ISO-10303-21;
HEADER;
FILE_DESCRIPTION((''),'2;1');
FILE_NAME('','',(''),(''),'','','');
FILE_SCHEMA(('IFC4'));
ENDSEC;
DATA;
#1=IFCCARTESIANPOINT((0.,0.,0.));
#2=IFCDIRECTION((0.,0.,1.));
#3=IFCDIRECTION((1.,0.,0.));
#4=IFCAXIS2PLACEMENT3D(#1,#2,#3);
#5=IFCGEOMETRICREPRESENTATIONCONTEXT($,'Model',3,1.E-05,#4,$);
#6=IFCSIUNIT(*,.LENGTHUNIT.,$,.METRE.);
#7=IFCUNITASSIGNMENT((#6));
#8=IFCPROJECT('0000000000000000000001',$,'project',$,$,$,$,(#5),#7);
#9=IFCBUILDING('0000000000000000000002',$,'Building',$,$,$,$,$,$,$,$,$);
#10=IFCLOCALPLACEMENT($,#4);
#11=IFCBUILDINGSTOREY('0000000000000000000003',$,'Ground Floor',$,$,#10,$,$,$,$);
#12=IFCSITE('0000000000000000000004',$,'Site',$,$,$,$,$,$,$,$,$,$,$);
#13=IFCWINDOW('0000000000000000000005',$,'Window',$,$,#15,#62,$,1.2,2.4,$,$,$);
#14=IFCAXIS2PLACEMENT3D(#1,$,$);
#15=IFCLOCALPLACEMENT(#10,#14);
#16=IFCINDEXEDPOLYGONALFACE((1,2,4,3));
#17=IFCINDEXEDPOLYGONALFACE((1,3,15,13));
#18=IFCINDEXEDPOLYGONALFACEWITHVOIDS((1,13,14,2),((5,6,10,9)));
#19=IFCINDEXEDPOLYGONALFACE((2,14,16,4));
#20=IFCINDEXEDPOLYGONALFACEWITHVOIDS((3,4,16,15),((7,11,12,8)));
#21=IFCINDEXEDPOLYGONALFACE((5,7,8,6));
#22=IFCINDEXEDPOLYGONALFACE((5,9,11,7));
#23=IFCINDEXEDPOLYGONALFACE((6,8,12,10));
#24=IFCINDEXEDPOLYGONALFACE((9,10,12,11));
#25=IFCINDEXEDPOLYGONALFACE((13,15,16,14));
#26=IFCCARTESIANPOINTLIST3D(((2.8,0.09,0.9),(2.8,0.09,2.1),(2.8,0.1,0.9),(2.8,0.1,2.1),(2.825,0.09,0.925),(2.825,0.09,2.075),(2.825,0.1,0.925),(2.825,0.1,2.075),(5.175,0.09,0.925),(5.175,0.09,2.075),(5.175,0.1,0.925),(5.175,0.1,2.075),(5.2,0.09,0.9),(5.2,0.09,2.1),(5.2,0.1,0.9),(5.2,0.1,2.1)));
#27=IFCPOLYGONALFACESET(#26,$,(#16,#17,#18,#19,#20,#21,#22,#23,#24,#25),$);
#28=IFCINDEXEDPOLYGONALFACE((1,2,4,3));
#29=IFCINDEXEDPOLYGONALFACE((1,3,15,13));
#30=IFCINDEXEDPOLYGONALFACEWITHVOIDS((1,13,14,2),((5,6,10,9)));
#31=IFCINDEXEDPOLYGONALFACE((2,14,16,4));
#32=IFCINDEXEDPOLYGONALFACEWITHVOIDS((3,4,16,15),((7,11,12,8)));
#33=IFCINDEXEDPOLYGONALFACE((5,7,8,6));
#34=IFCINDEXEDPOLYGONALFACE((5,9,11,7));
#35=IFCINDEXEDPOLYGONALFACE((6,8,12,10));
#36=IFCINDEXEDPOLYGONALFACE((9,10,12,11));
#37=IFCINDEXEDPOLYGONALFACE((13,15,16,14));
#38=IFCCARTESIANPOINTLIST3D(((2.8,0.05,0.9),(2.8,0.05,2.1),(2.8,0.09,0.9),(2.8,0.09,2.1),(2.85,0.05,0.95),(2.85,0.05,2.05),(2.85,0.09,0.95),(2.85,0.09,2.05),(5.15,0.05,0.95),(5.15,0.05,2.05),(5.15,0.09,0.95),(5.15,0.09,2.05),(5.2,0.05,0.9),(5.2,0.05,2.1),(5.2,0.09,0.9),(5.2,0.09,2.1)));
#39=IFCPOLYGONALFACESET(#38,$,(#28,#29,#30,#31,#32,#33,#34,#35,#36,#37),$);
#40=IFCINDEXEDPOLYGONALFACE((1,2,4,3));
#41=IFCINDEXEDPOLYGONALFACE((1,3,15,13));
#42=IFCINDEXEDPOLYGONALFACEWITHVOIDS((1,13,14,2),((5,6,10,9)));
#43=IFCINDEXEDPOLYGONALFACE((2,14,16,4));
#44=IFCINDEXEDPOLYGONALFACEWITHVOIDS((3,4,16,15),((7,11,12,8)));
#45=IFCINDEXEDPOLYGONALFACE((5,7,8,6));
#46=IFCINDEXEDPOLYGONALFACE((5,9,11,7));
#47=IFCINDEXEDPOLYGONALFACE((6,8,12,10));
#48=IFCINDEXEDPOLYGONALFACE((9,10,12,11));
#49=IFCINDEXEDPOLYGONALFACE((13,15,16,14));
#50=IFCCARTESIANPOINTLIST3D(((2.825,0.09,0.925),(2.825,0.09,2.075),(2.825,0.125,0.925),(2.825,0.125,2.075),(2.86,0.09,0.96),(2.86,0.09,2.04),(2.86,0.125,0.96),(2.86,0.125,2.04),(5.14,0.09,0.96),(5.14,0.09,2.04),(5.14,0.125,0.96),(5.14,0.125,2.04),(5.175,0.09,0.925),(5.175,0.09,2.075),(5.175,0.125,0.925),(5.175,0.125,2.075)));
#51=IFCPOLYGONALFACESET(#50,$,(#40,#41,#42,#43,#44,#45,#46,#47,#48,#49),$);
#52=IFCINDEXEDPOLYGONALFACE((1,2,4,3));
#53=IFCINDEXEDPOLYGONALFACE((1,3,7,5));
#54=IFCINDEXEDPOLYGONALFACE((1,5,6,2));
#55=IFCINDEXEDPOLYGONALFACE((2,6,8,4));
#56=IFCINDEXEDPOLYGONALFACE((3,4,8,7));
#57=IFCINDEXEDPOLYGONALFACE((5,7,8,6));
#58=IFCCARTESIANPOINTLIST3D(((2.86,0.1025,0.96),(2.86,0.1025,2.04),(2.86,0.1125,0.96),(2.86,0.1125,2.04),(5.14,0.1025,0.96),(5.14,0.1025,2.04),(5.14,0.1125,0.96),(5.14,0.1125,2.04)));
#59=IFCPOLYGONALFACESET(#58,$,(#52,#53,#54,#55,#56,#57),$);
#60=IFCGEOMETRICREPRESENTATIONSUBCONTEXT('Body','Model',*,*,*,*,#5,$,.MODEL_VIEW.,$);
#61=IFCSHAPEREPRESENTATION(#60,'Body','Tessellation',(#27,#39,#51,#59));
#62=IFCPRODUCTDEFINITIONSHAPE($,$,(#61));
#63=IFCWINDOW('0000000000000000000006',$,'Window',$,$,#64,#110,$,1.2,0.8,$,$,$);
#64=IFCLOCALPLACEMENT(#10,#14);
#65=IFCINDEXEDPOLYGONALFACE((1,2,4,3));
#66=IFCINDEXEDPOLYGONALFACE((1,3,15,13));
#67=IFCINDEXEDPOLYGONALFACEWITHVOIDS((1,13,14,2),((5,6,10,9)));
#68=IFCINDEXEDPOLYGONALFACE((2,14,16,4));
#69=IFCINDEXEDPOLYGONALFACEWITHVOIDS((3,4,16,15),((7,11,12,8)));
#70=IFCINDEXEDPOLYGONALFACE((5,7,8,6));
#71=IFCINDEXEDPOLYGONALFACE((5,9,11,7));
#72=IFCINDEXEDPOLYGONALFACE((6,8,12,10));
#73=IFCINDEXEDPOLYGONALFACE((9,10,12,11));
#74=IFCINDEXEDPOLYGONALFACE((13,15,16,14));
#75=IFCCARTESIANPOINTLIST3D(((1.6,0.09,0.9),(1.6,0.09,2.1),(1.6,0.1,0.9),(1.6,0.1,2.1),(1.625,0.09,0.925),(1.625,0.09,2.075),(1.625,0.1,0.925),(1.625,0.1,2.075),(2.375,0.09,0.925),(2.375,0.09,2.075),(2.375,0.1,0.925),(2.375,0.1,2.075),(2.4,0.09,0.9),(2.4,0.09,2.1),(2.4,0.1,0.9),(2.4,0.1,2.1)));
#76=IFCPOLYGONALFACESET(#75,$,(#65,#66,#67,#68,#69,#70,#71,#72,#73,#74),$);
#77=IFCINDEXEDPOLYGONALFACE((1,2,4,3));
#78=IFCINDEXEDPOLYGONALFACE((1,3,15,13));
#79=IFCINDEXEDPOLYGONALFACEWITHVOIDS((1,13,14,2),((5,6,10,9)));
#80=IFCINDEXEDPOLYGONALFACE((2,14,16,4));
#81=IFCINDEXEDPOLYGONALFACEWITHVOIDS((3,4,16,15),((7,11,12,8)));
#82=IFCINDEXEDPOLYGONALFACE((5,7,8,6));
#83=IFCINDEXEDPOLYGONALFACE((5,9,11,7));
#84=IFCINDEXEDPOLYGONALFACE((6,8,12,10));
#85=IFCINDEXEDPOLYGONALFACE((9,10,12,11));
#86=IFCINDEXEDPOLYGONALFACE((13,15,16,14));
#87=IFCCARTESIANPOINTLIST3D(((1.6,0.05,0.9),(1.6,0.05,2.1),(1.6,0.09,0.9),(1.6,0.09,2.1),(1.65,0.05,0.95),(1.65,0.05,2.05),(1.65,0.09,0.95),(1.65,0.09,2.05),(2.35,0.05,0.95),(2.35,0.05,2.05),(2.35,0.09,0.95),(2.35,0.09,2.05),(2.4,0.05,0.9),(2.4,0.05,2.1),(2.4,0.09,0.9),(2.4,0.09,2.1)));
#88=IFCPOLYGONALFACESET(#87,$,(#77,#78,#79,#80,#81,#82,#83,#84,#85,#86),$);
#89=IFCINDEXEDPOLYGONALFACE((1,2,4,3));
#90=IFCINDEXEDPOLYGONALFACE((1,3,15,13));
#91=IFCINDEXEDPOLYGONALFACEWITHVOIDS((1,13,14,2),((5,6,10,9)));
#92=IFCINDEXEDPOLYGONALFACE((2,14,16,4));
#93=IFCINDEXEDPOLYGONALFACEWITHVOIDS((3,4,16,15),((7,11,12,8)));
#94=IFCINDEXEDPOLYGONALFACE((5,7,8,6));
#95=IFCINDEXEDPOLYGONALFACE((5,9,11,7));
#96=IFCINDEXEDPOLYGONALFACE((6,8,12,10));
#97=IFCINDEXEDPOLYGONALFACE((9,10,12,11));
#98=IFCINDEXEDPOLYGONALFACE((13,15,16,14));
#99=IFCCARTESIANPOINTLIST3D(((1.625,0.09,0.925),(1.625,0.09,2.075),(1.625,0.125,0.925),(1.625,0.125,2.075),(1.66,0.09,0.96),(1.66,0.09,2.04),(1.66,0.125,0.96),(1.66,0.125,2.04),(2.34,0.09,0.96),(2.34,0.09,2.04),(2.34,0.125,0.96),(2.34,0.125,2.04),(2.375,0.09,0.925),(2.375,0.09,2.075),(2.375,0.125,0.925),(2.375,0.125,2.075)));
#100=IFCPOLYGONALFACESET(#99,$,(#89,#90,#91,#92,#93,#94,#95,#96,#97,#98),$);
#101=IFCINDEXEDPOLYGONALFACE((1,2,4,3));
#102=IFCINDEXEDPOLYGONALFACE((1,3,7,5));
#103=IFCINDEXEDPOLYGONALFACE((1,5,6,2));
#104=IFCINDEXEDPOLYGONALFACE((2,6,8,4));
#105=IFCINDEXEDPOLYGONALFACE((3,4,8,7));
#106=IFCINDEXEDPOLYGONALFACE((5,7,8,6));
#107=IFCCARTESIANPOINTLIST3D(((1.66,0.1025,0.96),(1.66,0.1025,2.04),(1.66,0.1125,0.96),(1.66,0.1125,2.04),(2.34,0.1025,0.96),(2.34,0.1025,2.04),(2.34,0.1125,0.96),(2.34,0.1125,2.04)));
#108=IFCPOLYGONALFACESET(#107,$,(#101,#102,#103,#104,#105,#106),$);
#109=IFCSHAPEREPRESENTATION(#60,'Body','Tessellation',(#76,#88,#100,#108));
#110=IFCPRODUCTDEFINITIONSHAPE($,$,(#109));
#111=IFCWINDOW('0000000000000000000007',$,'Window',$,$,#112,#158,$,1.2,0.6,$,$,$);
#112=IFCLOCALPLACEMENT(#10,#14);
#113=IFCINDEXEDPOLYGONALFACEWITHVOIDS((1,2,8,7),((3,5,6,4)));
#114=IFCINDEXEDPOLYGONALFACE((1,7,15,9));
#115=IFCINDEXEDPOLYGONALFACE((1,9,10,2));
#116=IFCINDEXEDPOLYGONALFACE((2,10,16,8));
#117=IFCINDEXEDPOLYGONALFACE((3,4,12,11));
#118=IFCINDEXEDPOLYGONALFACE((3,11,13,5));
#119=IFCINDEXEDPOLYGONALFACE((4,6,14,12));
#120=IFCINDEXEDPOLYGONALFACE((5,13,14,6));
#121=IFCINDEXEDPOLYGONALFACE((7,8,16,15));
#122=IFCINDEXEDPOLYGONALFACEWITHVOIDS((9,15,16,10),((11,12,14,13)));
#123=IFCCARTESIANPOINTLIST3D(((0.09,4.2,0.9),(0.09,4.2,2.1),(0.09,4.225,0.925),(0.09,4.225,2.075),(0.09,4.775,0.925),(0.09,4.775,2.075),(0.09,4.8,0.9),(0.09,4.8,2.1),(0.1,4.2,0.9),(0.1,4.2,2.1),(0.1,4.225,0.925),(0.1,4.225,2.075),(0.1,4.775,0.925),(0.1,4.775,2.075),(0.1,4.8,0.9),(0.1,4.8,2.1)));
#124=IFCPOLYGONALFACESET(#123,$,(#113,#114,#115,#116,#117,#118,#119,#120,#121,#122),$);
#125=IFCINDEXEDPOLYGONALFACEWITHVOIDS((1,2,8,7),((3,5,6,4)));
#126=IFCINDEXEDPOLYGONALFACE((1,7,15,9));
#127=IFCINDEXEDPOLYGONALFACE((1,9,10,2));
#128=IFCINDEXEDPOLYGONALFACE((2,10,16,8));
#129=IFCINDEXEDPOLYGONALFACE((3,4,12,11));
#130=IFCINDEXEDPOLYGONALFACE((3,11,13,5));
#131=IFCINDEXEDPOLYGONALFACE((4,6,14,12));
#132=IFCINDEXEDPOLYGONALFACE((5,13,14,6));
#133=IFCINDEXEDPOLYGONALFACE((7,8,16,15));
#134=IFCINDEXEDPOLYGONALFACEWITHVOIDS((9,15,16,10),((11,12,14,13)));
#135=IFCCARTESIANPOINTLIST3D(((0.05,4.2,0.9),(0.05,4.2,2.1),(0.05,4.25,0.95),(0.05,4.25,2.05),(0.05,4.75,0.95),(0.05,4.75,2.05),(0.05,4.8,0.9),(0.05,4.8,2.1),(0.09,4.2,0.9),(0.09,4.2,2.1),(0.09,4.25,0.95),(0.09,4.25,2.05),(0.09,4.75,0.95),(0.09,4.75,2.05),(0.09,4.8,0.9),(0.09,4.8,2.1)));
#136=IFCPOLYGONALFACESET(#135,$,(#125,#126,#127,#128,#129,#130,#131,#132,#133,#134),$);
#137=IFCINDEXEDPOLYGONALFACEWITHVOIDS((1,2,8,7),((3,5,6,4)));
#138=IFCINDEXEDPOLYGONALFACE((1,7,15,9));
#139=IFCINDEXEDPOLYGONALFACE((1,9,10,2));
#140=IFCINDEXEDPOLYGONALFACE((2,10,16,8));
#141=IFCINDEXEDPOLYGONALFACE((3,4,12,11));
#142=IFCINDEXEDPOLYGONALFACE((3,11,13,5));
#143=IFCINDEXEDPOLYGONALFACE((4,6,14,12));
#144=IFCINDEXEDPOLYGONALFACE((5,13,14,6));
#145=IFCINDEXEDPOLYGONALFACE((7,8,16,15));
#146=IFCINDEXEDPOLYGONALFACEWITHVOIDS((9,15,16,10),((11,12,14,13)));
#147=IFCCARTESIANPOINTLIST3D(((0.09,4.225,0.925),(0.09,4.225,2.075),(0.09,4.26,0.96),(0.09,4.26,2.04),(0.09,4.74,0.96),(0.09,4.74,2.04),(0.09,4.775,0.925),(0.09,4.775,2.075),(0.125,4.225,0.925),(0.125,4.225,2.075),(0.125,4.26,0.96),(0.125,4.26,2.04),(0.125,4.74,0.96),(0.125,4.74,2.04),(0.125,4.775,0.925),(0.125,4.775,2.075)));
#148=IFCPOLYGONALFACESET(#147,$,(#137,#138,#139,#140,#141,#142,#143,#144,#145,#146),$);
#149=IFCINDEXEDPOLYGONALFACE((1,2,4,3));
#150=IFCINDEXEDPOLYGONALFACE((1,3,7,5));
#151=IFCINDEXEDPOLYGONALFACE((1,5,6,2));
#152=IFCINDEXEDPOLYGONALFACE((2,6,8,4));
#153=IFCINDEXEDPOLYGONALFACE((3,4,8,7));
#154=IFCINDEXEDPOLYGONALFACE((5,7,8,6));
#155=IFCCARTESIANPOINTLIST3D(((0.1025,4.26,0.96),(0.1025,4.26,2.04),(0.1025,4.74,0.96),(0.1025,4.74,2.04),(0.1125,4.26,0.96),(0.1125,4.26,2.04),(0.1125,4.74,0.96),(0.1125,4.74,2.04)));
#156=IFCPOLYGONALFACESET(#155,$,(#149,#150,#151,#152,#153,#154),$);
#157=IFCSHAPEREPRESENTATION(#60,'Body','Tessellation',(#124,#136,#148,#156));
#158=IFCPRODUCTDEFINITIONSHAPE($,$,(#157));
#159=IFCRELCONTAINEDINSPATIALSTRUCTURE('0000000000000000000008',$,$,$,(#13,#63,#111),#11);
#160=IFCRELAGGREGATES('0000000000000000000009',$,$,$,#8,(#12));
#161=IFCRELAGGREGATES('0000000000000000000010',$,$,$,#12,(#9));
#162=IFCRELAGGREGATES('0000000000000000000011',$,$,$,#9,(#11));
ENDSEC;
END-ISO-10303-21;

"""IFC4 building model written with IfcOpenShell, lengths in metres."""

from ifc_helpers import new_model, si_unit, frame, origin_with_axes, place, context, subcontext, project, spatial, line, indexed_curve, outline, extrude, element, save


model = new_model("IFC4")

# Units and contexts
model_context = context("Model", 3, precision=1e-05, world=origin_with_axes())
body_context = subcontext(model_context, "Body", "Model", "MODEL_VIEW")
ifc_project = project(units=[si_unit("LENGTHUNIT", "METRE")], contexts=[model_context])

# Site, building, storey
site = spatial("IfcSite", under=ifc_project, Name="Site")
building = spatial("IfcBuilding", under=site, Name="Building")
storey_placement = place(None, origin_with_axes())
storey = spatial("IfcBuildingStorey", under=building, at=storey_placement, Name="Ground Floor")

# Windows
window_1_placement = place(storey_placement, frame((2.8, 0.0, 0.9), z_axis=(0.0, 0.0, 1.0), x_axis=(1.0, 0.0, 0.0)))
element("IfcWindow", 1, at=window_1_placement, inside=storey, Name="Window", OverallHeight=1.2, OverallWidth=2.4, context=body_context, shape_type="SweptSolid", body=[
    extrude(outline(indexed_curve([(0.0, 0.0), (2.4, 0.0), (2.4, 1.2), (0.0, 1.2)], segments=[line(1, 2, 3, 4, 1)]), holes=[indexed_curve([(0.025, 0.025), (2.375, 0.025), (2.375, 1.175), (0.025, 1.175)], segments=[line(1, 2, 3, 4, 1)])]), frame((0.0, 0.09, 0.0), z_axis=(0.0, -1.0, 0.0), x_axis=(1.0, 0.0, 0.0)), (0.0, 0.0, -1.0), 0.01),
    extrude(outline(indexed_curve([(0.0, 0.0), (2.4, 0.0), (2.4, 1.2), (0.0, 1.2)], segments=[line(1, 2, 3, 4, 1)]), holes=[indexed_curve([(0.05, 0.05), (2.35, 0.05), (2.35, 1.15), (0.05, 1.15)], segments=[line(1, 2, 3, 4, 1)])]), frame((0.0, 0.05, 0.0), z_axis=(0.0, -1.0, 0.0), x_axis=(1.0, 0.0, 0.0)), (0.0, 0.0, -1.0), 0.04),
    extrude(outline(indexed_curve([(0.0, 0.0), (2.35, 0.0), (2.35, 1.15), (0.0, 1.15)], segments=[line(1, 2, 3, 4, 1)]), holes=[indexed_curve([(0.035, 0.035), (2.315, 0.035), (2.315, 1.115), (0.035, 1.115)], segments=[line(1, 2, 3, 4, 1)])]), frame((0.025, 0.09, 0.025), z_axis=(0.0, -1.0, 0.0), x_axis=(1.0, 0.0, 0.0)), (0.0, 0.0, -1.0), 0.035),
    extrude(outline(indexed_curve([(0.035, 0.035), (2.315, 0.035), (2.315, 1.115), (0.035, 1.115)], segments=[line(1, 2, 3, 4, 1)])), frame((0.025, 0.1025, 0.025), z_axis=(0.0, -1.0, 0.0), x_axis=(1.0, 0.0, 0.0)), (0.0, 0.0, -1.0), 0.01),
])
window_2_placement = place(storey_placement, frame((1.6, 0.0, 0.9), z_axis=(0.0, 0.0, 1.0), x_axis=(1.0, 0.0, 0.0)))
element("IfcWindow", 2, at=window_2_placement, inside=storey, Name="Window", OverallHeight=1.2, OverallWidth=0.8, context=body_context, shape_type="SweptSolid", body=[
    extrude(outline(indexed_curve([(0.0, 0.0), (0.8, 0.0), (0.8, 1.2), (0.0, 1.2)], segments=[line(1, 2, 3, 4, 1)]), holes=[indexed_curve([(0.025, 0.025), (0.775, 0.025), (0.775, 1.175), (0.025, 1.175)], segments=[line(1, 2, 3, 4, 1)])]), frame((0.0, 0.09, 0.0), z_axis=(0.0, -1.0, 0.0), x_axis=(1.0, 0.0, 0.0)), (0.0, 0.0, -1.0), 0.01),
    extrude(outline(indexed_curve([(0.0, 0.0), (0.8, 0.0), (0.8, 1.2), (0.0, 1.2)], segments=[line(1, 2, 3, 4, 1)]), holes=[indexed_curve([(0.05, 0.05), (0.75, 0.05), (0.75, 1.15), (0.05, 1.15)], segments=[line(1, 2, 3, 4, 1)])]), frame((0.0, 0.05, 0.0), z_axis=(0.0, -1.0, 0.0), x_axis=(1.0, 0.0, 0.0)), (0.0, 0.0, -1.0), 0.04),
    extrude(outline(indexed_curve([(0.0, 0.0), (0.75, 0.0), (0.75, 1.15), (0.0, 1.15)], segments=[line(1, 2, 3, 4, 1)]), holes=[indexed_curve([(0.035, 0.035), (0.715, 0.035), (0.715, 1.115), (0.035, 1.115)], segments=[line(1, 2, 3, 4, 1)])]), frame((0.025, 0.09, 0.025), z_axis=(0.0, -1.0, 0.0), x_axis=(1.0, 0.0, 0.0)), (0.0, 0.0, -1.0), 0.035),
    extrude(outline(indexed_curve([(0.035, 0.035), (0.715, 0.035), (0.715, 1.115), (0.035, 1.115)], segments=[line(1, 2, 3, 4, 1)])), frame((0.025, 0.1025, 0.025), z_axis=(0.0, -1.0, 0.0), x_axis=(1.0, 0.0, 0.0)), (0.0, 0.0, -1.0), 0.01),
])
window_3_placement = place(storey_placement, frame((0.0, 4.8, 0.9), z_axis=(0.0, 0.0, 1.0), x_axis=(0.0, -1.0, 0.0)))
element("IfcWindow", 3, at=window_3_placement, inside=storey, Name="Window", OverallHeight=1.2, OverallWidth=0.6, context=body_context, shape_type="SweptSolid", body=[
    extrude(outline(indexed_curve([(0.0, 0.0), (0.6, 0.0), (0.6, 1.2), (0.0, 1.2)], segments=[line(1, 2, 3, 4, 1)]), holes=[indexed_curve([(0.025, 0.025), (0.575, 0.025), (0.575, 1.175), (0.025, 1.175)], segments=[line(1, 2, 3, 4, 1)])]), frame((0.0, 0.09, 0.0), z_axis=(0.0, -1.0, 0.0), x_axis=(1.0, 0.0, 0.0)), (0.0, 0.0, -1.0), 0.01),
    extrude(outline(indexed_curve([(0.0, 0.0), (0.6, 0.0), (0.6, 1.2), (0.0, 1.2)], segments=[line(1, 2, 3, 4, 1)]), holes=[indexed_curve([(0.05, 0.05), (0.55, 0.05), (0.55, 1.15), (0.05, 1.15)], segments=[line(1, 2, 3, 4, 1)])]), frame((0.0, 0.05, 0.0), z_axis=(0.0, -1.0, 0.0), x_axis=(1.0, 0.0, 0.0)), (0.0, 0.0, -1.0), 0.04),
    extrude(outline(indexed_curve([(0.0, 0.0), (0.55, 0.0), (0.55, 1.15), (0.0, 1.15)], segments=[line(1, 2, 3, 4, 1)]), holes=[indexed_curve([(0.035, 0.035), (0.515, 0.035), (0.515, 1.115), (0.035, 1.115)], segments=[line(1, 2, 3, 4, 1)])]), frame((0.025, 0.09, 0.025), z_axis=(0.0, -1.0, 0.0), x_axis=(1.0, 0.0, 0.0)), (0.0, 0.0, -1.0), 0.035),
    extrude(outline(indexed_curve([(0.035, 0.035), (0.515, 0.035), (0.515, 1.115), (0.035, 1.115)], segments=[line(1, 2, 3, 4, 1)])), frame((0.025, 0.1025, 0.025), z_axis=(0.0, -1.0, 0.0), x_axis=(1.0, 0.0, 0.0)), (0.0, 0.0, -1.0), 0.01),
])

save(model, "model.ifc")
